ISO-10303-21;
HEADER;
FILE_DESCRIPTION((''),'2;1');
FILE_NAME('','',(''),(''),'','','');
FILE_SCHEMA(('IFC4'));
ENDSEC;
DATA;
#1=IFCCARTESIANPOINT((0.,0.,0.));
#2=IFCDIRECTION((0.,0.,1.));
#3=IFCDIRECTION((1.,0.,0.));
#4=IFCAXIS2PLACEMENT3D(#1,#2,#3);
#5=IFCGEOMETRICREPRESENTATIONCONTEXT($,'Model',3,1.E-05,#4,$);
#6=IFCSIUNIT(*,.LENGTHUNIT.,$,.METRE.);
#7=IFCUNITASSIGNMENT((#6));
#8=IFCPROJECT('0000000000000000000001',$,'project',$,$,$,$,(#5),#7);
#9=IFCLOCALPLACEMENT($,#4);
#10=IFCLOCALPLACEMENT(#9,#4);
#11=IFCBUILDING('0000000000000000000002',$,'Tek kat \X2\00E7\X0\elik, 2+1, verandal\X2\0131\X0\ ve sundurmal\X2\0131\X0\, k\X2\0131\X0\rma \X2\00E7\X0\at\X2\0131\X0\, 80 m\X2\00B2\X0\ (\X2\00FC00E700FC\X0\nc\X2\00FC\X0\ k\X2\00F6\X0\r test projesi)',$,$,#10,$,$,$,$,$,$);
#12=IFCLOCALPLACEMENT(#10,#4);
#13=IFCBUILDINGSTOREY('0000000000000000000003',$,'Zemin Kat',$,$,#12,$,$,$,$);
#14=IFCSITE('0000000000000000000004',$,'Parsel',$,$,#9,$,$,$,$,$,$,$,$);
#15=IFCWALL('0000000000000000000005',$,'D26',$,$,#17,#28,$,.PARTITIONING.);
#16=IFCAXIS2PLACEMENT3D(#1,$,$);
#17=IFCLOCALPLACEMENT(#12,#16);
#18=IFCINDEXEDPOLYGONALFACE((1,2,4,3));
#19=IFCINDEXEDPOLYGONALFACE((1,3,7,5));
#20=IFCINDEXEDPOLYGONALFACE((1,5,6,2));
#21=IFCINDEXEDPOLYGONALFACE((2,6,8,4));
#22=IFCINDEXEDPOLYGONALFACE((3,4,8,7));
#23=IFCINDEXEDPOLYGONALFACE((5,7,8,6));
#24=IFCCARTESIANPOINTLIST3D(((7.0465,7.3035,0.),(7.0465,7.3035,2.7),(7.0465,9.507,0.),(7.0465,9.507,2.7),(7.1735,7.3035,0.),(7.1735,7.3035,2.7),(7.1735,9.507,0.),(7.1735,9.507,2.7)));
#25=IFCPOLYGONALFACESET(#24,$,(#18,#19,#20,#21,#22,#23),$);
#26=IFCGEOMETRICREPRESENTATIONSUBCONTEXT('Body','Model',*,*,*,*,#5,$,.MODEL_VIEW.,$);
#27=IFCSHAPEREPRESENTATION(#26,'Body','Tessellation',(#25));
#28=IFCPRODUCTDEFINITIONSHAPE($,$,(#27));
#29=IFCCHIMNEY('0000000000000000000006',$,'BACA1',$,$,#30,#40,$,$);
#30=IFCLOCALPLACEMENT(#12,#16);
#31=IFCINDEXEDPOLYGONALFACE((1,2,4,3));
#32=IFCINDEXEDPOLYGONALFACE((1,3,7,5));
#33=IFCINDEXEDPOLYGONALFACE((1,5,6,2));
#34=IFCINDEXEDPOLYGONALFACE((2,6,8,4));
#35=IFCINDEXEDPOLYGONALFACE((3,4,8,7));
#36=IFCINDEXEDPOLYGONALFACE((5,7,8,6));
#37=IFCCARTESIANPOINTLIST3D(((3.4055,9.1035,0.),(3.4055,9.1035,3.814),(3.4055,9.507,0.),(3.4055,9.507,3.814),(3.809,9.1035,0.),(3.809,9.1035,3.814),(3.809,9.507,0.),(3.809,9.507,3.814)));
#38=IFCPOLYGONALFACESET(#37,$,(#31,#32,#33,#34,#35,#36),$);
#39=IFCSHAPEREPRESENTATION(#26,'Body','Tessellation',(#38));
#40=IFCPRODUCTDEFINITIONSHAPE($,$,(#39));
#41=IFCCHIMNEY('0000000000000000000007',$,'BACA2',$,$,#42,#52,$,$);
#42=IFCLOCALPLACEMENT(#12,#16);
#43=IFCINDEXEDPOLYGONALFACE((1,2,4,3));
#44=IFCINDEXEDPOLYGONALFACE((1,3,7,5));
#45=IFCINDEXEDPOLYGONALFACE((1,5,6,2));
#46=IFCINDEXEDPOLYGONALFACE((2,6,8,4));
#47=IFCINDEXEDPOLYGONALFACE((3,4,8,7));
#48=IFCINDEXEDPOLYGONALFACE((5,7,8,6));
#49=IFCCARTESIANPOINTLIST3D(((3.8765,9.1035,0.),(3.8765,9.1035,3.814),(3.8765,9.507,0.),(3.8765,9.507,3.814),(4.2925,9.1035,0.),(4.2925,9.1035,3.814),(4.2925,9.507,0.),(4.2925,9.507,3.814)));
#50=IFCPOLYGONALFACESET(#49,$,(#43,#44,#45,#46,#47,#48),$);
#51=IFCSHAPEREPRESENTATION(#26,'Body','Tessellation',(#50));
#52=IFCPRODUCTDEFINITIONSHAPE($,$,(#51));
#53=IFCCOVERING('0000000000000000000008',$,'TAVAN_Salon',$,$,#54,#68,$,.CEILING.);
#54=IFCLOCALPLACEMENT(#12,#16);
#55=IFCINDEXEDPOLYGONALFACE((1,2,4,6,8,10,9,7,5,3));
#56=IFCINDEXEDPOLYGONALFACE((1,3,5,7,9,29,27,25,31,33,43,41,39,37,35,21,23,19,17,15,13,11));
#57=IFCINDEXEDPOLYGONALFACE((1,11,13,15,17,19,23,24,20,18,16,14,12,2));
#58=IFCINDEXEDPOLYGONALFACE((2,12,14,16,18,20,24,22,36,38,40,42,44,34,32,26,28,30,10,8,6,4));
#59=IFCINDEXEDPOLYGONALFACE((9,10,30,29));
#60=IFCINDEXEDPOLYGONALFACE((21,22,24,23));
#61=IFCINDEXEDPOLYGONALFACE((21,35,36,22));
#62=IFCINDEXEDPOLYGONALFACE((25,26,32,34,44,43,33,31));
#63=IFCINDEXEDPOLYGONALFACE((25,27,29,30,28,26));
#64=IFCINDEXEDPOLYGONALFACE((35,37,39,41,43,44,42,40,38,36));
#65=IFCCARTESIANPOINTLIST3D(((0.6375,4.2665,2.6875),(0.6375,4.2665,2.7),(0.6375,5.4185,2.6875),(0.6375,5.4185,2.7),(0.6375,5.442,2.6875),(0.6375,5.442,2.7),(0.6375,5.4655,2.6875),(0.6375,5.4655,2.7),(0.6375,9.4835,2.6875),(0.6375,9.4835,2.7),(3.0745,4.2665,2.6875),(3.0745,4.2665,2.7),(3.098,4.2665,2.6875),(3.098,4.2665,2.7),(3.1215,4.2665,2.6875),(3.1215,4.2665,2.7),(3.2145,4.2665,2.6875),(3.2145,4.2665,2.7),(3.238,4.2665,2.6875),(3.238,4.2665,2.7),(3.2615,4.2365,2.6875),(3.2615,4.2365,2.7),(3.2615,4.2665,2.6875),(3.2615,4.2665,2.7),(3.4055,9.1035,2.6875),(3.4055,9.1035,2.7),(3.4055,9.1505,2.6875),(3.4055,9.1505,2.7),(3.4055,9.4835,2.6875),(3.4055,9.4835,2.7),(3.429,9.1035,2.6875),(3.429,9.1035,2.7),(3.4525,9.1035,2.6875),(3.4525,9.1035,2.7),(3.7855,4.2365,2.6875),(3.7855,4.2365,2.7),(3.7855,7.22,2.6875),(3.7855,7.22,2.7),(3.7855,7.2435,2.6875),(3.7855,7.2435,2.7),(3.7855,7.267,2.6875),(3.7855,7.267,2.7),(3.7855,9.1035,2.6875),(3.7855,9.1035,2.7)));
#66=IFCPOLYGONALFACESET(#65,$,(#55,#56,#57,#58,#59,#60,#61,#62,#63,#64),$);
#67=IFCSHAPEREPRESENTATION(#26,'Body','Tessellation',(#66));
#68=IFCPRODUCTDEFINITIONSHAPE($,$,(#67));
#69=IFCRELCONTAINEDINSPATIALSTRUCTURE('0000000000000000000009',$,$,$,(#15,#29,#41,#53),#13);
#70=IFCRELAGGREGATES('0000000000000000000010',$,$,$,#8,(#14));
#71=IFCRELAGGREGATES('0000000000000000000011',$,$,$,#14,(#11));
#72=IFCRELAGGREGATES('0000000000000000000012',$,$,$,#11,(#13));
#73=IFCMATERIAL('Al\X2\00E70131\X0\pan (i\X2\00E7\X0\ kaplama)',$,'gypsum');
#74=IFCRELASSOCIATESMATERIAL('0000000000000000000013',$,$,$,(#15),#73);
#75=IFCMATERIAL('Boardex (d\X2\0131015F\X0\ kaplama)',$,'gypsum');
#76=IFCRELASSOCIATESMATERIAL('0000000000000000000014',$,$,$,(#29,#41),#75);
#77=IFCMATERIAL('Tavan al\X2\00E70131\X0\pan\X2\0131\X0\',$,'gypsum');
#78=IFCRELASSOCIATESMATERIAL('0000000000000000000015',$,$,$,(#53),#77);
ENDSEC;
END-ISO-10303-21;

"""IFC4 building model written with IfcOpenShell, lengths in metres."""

from ifc_helpers import new_model, si_unit, frame, origin_with_axes, place, context, subcontext, project, spatial, line, indexed_curve, outline, extrude, material, element, save


model = new_model("IFC4")

# Units and contexts
model_context = context("Model", 3, precision=1e-05, world=origin_with_axes())
body_context = subcontext(model_context, "Body", "Model", "MODEL_VIEW")
ifc_project = project(units=[si_unit("LENGTHUNIT", "METRE")], contexts=[model_context])

# Site, building, storey
site_placement = place(None, origin_with_axes())
site = spatial("IfcSite", under=ifc_project, at=site_placement, Name="Parsel")
building_placement = place(site_placement, origin_with_axes())
building = spatial("IfcBuilding", under=site, at=building_placement, Name="Tek kat çelik, 2+1, verandalı ve sundurmalı, kırma çatı, 80 m² (üçüncü kör test projesi)")
storey_placement = place(building_placement, origin_with_axes())
storey = spatial("IfcBuildingStorey", under=building, at=storey_placement, Name="Zemin Kat")

# Shared definitions
ifc_material_1 = material(Name="Boardex (dış kaplama)", Category="gypsum")

# Shared definitions
ifc_material_2 = material(Name="Alçıpan (iç kaplama)", Category="gypsum")

# Wall
wall_1_placement = place(storey_placement, origin_with_axes())
element("IfcWall", 1, at=wall_1_placement, inside=storey, material=ifc_material_2, Name="D26", PredefinedType="PARTITIONING", context=body_context, shape_type="SweptSolid", body=[
    extrude(outline(indexed_curve([(0.0, 0.0), (0.127, 0.0), (0.127, 2.2035), (0.0, 2.2035)], segments=[line(1, 2, 3, 4, 1)])), frame((7.0465, 7.3035, 0.0), z_axis=(0.0, 0.0, 1.0), x_axis=(1.0, 0.0, 0.0)), (0.0, 0.0, 1.0), 2.7),
])

# Chimneys
chimney_1_placement = place(storey_placement, origin_with_axes())
element("IfcChimney", 2, at=chimney_1_placement, inside=storey, material=ifc_material_1, Name="BACA1", context=body_context, shape_type="SweptSolid", body=[
    extrude(outline(indexed_curve([(0.0, 0.0), (0.4035, 0.0), (0.4035, 0.4035), (0.0, 0.4035)], segments=[line(1, 2, 3, 4, 1)])), frame((3.4055, 9.1035, 0.0), z_axis=(0.0, 0.0, 1.0), x_axis=(1.0, 0.0, 0.0)), (0.0, 0.0, 1.0), 3.814),
])
chimney_2_placement = place(storey_placement, origin_with_axes())
element("IfcChimney", 3, at=chimney_2_placement, inside=storey, material=ifc_material_1, Name="BACA2", context=body_context, shape_type="SweptSolid", body=[
    extrude(outline(indexed_curve([(0.0, 0.0), (0.416, 0.0), (0.416, 0.4035), (0.0, 0.4035)], segments=[line(1, 2, 3, 4, 1)])), frame((3.8765, 9.1035, 0.0), z_axis=(0.0, 0.0, 1.0), x_axis=(1.0, 0.0, 0.0)), (0.0, 0.0, 1.0), 3.814),
])

# Covering
ifc_material_3 = material(Name="Tavan alçıpanı", Category="gypsum")
covering_placement = place(storey_placement, origin_with_axes())
element("IfcCovering", 4, at=covering_placement, inside=storey, material=ifc_material_3, Name="TAVAN_Salon", PredefinedType="CEILING", context=body_context, shape_type="SweptSolid", body=[
    extrude(outline(indexed_curve([(0.6375, 9.4835), (3.4055, 9.4835), (3.4055, 9.1505), (3.4055, 9.1035), (3.429, 9.1035), (3.4525, 9.1035), (3.7855, 9.1035), (3.7855, 7.267), (3.7855, 7.2435), (3.7855, 7.22), (3.7855, 4.2365), (3.2615, 4.2365), (3.2615, 4.2665), (3.238, 4.2665), (3.2145, 4.2665), (3.1215, 4.2665), (3.098, 4.2665), (3.0745, 4.2665), (0.6375, 4.2665), (0.6375, 5.4185), (0.6375, 5.442), (0.6375, 5.4655)], segments=[line(1, 2, 3, 4, 5, 6, 7, 8, 9, 10, 11, 12, 13, 14, 15, 16, 17, 18, 19, 20, 21, 22, 1)])), frame((0.0, 0.0, 2.6875), z_axis=(0.0, 0.0, 1.0), x_axis=(1.0, 0.0, 0.0)), (0.0, 0.0, 1.0), 0.0125),
])

save(model, "model.ifc")
